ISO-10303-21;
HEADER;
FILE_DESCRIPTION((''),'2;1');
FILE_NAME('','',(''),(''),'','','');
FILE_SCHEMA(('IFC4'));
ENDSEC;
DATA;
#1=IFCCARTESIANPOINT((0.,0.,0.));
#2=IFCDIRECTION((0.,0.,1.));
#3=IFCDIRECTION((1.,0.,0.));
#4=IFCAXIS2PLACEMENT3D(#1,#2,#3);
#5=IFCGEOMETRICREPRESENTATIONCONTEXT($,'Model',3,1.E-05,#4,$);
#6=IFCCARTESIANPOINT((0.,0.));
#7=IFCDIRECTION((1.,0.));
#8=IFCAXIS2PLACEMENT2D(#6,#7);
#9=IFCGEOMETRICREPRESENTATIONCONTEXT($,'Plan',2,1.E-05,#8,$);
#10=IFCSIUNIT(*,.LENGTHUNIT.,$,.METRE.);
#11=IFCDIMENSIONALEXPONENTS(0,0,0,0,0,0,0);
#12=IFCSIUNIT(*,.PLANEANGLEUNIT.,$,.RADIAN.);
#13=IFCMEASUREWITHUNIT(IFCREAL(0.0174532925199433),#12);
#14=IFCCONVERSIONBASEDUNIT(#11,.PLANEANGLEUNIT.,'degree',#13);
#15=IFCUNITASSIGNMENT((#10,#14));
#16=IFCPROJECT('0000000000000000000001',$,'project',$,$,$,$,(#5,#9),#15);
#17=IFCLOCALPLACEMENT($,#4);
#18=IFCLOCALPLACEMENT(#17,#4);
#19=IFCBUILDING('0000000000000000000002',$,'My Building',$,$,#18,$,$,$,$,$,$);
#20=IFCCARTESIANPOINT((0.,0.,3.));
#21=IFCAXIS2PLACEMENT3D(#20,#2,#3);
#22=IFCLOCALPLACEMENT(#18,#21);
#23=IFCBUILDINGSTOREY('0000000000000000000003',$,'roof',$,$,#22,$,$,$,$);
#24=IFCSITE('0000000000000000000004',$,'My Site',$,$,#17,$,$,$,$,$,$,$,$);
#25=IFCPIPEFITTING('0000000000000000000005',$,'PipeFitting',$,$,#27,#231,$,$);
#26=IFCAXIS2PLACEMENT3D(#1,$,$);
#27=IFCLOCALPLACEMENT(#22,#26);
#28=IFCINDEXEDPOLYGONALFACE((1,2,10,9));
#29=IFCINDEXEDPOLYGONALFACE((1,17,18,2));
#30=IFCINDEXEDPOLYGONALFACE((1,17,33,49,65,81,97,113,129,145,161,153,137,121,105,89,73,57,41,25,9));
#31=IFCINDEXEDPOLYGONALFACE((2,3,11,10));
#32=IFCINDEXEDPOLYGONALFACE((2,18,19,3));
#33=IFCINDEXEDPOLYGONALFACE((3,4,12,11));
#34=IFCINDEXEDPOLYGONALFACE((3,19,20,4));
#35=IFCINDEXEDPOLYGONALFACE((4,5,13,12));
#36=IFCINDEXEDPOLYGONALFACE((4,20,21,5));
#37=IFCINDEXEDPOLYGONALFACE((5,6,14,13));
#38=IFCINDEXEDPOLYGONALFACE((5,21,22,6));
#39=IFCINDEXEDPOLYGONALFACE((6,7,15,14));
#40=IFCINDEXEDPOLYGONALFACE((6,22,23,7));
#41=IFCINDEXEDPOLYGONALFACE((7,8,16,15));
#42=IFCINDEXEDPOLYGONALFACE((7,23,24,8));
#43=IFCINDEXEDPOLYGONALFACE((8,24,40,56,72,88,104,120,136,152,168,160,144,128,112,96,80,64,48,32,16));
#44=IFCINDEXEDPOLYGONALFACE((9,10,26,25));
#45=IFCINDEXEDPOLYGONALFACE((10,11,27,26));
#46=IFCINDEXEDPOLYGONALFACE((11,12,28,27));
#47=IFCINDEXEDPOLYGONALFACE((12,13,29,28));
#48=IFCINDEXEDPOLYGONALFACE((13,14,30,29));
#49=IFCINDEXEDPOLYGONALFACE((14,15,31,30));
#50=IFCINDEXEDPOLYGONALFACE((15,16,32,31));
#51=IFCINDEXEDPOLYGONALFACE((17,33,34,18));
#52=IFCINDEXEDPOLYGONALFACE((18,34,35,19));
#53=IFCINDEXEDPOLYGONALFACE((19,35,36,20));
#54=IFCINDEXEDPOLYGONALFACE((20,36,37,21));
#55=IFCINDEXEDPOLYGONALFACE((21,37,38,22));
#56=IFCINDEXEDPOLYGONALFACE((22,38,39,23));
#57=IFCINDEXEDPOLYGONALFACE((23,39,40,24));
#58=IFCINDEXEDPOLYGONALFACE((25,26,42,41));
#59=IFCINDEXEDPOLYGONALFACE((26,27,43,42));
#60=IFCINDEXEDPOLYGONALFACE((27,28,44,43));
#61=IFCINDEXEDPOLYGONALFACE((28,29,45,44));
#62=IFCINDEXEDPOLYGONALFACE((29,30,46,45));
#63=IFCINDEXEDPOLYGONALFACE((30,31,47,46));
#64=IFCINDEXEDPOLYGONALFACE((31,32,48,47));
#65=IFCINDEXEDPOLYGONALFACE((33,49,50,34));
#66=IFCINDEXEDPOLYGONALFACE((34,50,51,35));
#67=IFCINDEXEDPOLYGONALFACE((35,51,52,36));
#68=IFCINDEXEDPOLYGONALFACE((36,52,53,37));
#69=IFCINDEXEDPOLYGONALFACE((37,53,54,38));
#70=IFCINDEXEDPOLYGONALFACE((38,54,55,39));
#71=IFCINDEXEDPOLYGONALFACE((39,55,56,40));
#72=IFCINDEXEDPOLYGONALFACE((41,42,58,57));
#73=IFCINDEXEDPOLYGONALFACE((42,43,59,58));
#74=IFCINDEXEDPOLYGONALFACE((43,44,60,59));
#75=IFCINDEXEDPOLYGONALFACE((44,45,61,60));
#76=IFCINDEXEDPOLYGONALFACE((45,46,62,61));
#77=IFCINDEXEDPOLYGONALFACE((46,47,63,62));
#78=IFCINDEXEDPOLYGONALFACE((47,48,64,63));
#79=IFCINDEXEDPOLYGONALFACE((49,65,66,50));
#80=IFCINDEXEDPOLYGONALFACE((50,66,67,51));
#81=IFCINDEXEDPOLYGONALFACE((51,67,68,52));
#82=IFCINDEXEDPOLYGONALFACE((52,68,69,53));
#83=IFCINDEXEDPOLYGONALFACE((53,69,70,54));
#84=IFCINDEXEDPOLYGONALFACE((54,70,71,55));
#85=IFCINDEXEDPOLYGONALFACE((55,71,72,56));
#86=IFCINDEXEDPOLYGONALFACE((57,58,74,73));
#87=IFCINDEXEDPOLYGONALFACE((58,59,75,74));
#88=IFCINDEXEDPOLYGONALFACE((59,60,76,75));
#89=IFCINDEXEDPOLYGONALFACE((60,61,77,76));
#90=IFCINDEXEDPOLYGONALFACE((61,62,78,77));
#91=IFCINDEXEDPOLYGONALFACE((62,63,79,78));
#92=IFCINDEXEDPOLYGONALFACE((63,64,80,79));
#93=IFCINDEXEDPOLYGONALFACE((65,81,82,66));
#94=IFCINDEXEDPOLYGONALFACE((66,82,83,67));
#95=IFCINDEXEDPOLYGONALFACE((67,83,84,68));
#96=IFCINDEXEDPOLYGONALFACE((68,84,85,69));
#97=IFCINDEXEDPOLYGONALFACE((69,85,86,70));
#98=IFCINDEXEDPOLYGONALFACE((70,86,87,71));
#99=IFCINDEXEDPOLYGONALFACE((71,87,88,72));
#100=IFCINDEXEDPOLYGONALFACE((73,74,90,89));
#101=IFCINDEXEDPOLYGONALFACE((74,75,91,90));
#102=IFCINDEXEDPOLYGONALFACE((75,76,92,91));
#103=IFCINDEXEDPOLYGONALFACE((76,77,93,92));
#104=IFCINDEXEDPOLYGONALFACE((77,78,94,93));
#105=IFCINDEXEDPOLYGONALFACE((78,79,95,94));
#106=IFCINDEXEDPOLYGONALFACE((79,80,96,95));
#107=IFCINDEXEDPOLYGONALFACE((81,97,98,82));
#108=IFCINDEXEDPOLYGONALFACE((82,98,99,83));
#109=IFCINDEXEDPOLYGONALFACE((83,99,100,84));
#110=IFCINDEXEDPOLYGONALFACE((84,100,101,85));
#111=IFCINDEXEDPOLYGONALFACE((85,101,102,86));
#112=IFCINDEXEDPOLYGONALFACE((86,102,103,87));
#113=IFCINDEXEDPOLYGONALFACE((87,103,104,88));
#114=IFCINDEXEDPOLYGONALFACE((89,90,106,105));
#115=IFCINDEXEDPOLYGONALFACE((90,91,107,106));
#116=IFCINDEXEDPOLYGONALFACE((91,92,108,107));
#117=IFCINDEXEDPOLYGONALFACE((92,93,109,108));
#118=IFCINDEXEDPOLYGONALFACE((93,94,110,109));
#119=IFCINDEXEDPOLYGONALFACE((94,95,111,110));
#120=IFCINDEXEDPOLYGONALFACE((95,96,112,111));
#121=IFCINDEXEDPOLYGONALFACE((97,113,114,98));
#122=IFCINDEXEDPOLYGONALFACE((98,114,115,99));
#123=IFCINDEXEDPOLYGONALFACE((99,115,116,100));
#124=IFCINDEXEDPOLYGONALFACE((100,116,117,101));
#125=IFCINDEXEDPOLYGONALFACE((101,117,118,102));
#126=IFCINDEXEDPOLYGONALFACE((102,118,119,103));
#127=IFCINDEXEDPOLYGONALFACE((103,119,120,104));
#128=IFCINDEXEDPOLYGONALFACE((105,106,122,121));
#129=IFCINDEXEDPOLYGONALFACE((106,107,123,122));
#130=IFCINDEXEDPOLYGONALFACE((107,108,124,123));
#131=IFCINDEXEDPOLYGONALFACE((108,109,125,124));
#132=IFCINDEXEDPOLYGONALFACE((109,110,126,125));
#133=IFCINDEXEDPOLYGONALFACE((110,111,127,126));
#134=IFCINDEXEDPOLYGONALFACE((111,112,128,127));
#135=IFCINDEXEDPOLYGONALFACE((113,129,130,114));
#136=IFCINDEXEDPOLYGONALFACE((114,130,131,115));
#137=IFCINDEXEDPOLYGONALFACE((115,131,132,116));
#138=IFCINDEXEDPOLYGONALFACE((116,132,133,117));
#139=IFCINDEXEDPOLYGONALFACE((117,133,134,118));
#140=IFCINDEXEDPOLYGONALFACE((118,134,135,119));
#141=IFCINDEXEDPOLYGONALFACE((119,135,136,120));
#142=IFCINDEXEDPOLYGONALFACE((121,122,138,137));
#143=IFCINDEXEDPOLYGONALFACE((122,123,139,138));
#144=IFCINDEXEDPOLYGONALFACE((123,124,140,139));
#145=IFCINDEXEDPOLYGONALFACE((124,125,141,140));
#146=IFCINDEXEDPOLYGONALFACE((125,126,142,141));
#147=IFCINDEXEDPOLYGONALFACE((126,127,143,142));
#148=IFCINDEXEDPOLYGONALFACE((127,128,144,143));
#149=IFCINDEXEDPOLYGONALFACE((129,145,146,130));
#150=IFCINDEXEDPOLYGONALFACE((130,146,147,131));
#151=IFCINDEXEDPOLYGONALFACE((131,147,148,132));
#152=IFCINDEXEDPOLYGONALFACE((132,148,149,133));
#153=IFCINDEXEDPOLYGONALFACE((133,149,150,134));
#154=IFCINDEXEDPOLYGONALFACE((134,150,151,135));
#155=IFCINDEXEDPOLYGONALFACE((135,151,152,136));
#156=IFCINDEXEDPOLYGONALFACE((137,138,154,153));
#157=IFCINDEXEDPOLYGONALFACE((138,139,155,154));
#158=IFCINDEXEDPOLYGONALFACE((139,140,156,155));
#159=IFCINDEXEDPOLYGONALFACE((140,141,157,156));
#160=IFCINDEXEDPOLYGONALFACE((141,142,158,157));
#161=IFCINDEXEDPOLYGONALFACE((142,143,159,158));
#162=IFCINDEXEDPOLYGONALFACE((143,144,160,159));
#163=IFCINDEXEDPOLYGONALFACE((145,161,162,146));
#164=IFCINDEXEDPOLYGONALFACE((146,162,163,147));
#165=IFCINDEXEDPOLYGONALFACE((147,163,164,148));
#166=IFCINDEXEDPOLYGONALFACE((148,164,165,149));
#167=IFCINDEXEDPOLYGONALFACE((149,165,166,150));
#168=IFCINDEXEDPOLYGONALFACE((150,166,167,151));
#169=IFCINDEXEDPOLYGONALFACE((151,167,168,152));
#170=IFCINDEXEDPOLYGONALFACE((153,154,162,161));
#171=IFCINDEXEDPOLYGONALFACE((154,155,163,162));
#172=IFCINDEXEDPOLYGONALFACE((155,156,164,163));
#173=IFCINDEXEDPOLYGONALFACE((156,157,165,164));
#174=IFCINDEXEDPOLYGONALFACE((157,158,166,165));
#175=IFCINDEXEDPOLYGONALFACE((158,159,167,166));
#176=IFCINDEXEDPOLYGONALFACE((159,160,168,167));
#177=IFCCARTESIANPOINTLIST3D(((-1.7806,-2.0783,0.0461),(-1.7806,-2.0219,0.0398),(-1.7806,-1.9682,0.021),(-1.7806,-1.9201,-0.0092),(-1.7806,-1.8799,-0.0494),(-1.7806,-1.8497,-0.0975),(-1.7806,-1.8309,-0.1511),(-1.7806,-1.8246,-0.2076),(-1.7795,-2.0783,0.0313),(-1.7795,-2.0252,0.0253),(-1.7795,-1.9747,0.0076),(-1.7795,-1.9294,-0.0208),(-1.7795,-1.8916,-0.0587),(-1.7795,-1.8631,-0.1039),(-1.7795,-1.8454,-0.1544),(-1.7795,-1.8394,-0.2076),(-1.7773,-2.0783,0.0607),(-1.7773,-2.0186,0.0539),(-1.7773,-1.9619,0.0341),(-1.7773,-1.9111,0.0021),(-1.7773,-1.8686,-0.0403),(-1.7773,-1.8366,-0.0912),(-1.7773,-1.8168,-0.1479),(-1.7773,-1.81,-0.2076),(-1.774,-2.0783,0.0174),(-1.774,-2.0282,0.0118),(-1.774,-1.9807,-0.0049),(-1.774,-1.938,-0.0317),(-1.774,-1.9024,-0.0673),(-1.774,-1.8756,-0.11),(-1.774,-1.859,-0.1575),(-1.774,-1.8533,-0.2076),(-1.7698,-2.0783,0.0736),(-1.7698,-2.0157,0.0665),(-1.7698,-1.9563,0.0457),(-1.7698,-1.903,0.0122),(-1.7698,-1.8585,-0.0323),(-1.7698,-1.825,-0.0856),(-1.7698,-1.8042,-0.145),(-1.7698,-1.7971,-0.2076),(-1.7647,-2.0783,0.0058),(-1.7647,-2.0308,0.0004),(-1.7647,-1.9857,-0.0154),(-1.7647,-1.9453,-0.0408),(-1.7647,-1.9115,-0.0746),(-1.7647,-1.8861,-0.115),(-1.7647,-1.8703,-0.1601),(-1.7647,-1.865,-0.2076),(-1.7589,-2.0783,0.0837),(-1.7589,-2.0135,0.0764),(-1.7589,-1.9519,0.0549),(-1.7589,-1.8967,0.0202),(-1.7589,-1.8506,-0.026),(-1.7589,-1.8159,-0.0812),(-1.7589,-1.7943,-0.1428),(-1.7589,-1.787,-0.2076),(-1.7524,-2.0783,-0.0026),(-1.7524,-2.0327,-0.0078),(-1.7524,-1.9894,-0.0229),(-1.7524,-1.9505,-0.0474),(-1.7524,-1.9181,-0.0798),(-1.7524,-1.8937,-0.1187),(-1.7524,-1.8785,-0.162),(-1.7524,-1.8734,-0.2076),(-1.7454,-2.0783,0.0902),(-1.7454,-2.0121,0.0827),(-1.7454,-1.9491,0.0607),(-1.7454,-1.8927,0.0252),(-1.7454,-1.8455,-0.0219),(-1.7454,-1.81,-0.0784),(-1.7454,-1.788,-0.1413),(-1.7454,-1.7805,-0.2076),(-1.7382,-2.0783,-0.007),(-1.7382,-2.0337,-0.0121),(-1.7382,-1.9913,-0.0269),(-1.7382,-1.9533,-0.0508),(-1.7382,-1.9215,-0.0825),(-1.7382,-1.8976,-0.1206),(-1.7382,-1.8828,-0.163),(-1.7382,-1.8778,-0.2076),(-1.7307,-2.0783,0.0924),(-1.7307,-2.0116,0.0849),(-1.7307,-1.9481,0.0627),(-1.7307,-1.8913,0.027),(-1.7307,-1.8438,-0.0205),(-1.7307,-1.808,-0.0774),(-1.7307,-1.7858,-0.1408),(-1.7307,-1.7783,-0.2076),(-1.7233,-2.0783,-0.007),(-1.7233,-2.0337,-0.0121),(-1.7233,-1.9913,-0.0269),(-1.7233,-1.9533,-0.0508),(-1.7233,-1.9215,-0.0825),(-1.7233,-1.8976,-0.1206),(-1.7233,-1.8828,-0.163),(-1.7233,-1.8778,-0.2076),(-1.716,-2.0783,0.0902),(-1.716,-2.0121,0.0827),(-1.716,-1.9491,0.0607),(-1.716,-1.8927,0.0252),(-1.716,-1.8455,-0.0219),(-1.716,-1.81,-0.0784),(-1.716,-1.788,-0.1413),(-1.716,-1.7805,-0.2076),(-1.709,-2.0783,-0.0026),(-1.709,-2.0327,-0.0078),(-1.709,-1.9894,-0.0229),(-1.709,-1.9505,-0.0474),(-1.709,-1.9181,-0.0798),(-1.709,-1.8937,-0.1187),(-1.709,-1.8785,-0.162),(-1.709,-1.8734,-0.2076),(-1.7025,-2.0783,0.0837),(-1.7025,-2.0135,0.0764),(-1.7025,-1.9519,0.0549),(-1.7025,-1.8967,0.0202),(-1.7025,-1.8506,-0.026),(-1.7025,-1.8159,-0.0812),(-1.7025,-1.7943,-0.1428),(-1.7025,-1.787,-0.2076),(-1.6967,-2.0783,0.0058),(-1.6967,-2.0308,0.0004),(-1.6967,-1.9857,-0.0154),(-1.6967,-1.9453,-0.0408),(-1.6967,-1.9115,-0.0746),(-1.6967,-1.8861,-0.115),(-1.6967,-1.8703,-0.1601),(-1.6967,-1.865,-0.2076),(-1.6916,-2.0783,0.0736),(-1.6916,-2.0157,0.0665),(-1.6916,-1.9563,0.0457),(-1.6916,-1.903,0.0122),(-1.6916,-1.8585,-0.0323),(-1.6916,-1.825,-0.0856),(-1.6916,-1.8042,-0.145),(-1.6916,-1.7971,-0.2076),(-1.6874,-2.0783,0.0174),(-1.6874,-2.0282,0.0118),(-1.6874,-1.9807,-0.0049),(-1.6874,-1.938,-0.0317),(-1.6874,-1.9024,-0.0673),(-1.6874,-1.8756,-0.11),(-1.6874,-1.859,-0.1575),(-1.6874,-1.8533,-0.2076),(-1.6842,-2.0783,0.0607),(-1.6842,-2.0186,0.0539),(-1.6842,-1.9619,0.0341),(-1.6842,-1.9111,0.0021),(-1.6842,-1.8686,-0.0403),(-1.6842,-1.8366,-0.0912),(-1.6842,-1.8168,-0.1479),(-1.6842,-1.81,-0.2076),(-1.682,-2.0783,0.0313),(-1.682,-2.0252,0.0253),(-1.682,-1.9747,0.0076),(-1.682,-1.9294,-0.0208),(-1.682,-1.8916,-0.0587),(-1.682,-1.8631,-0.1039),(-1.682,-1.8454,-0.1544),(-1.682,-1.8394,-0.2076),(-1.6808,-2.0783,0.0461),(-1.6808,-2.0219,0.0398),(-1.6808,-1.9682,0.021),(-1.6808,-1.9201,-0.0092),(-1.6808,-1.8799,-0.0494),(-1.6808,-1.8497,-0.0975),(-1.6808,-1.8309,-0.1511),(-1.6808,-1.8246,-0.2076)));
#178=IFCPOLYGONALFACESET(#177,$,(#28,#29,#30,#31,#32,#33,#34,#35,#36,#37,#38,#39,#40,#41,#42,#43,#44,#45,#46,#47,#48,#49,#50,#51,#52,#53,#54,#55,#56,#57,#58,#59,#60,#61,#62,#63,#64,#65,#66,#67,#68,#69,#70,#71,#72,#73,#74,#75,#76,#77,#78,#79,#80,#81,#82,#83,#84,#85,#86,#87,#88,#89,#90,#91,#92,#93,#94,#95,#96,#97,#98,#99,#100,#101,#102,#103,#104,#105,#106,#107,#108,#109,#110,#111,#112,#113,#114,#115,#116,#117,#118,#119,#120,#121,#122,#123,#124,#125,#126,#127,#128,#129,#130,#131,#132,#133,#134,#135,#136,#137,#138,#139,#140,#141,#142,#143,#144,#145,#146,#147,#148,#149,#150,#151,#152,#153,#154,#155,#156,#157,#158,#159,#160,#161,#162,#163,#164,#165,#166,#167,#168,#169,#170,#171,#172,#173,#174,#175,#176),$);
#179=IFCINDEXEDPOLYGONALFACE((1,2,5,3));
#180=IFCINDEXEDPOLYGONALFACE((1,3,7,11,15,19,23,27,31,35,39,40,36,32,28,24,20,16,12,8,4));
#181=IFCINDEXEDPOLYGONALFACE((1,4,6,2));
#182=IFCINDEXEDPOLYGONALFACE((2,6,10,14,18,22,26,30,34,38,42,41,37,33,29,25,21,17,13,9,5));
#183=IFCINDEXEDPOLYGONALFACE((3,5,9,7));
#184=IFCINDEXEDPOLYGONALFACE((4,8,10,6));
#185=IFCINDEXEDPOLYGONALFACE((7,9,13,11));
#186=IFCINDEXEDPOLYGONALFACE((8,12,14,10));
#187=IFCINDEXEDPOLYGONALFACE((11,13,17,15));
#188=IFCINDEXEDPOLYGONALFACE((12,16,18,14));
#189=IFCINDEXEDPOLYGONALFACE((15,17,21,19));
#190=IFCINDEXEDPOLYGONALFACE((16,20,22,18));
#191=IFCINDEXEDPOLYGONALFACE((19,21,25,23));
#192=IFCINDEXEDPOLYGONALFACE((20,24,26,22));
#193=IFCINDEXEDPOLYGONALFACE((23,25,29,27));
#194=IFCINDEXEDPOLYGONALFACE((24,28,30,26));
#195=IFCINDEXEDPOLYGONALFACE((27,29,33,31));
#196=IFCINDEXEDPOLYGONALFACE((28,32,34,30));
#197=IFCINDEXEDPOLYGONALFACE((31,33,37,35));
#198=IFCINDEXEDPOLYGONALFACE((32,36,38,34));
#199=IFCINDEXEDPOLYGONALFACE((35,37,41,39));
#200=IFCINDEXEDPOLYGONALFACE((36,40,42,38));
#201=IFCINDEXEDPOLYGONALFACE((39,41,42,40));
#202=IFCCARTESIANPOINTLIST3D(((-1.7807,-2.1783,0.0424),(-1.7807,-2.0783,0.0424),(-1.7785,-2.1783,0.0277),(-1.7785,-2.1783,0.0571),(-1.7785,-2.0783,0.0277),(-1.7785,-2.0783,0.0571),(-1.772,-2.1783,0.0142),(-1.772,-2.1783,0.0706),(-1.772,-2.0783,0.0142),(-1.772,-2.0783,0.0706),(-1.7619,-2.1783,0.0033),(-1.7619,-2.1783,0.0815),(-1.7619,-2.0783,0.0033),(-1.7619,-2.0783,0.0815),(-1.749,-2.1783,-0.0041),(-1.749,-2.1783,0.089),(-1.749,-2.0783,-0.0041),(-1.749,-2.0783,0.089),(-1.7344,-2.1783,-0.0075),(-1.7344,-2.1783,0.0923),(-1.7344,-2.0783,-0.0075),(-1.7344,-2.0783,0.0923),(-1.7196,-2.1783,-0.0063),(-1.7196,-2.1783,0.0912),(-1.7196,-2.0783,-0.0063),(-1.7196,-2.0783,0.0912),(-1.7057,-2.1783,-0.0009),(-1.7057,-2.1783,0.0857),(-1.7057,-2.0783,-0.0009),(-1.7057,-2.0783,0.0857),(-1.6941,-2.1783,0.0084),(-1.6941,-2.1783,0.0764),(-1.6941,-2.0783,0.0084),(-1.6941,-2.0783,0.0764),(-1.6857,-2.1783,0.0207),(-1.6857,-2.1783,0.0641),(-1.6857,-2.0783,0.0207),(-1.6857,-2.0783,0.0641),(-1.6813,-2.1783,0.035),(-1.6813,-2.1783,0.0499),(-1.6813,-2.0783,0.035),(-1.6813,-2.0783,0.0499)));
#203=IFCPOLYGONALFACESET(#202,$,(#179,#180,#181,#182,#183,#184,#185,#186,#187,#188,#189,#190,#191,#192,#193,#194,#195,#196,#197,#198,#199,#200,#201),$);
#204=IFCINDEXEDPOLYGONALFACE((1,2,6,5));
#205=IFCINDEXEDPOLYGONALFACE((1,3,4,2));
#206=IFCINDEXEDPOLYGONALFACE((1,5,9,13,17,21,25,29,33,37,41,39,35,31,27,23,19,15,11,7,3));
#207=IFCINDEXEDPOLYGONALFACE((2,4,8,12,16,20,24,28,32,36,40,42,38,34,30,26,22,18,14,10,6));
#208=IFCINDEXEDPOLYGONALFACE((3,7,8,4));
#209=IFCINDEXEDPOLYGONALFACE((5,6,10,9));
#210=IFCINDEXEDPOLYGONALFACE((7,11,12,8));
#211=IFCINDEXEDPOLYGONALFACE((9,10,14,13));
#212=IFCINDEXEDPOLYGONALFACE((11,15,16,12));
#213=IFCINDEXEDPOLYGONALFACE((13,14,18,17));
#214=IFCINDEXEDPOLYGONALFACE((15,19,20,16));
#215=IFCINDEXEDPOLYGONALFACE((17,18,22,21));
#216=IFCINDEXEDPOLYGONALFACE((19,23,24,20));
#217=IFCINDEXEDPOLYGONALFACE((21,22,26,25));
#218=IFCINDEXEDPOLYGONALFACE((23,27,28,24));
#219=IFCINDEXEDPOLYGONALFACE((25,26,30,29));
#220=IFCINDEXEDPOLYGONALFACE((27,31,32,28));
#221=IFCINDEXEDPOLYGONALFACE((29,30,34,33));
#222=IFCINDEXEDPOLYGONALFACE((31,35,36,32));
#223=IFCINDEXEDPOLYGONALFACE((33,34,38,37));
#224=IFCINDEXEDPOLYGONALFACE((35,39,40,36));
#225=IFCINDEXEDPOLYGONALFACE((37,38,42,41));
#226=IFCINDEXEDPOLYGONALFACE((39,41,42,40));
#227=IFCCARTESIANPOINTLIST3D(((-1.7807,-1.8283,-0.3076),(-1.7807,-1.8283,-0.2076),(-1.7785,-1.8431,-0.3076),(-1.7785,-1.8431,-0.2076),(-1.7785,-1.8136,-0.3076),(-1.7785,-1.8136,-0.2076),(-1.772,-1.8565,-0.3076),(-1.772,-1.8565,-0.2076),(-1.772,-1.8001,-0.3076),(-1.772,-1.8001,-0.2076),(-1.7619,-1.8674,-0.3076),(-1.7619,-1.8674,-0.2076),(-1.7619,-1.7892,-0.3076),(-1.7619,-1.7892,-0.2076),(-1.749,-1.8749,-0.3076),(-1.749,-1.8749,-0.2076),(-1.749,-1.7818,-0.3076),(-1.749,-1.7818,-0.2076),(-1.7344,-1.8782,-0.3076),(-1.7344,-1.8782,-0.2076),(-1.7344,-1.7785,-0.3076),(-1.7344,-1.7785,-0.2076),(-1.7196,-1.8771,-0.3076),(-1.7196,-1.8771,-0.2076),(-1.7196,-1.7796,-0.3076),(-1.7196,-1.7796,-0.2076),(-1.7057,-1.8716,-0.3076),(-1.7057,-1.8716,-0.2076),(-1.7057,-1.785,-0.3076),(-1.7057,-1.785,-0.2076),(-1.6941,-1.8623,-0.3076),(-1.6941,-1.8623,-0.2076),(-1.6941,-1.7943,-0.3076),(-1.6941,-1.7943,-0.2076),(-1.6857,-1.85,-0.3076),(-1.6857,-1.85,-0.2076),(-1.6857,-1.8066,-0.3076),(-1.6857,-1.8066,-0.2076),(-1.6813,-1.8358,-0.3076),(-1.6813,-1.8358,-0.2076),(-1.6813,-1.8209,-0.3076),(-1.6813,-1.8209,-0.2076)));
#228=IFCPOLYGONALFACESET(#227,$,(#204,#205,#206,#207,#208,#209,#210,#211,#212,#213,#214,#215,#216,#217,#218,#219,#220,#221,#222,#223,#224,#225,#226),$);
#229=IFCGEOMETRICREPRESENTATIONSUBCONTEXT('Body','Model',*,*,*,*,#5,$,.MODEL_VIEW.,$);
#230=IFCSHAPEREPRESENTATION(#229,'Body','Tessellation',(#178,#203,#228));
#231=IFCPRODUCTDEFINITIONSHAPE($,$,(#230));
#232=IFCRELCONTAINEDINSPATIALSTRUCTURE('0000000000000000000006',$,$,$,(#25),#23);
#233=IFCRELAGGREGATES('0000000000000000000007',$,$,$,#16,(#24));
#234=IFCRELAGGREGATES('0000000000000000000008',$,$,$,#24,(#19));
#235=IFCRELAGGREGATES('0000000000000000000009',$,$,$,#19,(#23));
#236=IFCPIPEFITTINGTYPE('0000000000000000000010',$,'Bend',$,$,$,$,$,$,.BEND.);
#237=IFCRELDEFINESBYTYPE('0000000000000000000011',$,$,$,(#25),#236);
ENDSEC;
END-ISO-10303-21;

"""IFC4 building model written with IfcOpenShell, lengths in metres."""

from ifc_helpers import new_model, entity, si_unit, converted_unit, frame, origin_with_axes, origin_2d_with_axis, place, context, subcontext, project, spatial, circle, extrude, source, transform, mapped, type_object, type_shapes, element, save


model = new_model("IFC4")

# Units and contexts
model_context = context("Model", 3, precision=1e-05, world=origin_with_axes())
plan_context = context("Plan", 2, precision=1e-05, world=origin_2d_with_axis())
body_context = subcontext(model_context, "Body", "Model", "MODEL_VIEW")
ifc_project = project(units=[si_unit("LENGTHUNIT", "METRE"), converted_unit("PLANEANGLEUNIT", "degree", entity("IfcReal", 0.0174532925199433), si_unit("PLANEANGLEUNIT", "RADIAN"), dimensions=[0, 0, 0, 0, 0, 0, 0])], contexts=[model_context, plan_context])

# Site, building, storey
site_placement = place(None, origin_with_axes())
site = spatial("IfcSite", under=ifc_project, at=site_placement, Name="My Site")
building_placement = place(site_placement, origin_with_axes())
building = spatial("IfcBuilding", under=site, at=building_placement, Name="My Building")
storey_placement = place(building_placement, frame((0.0, 0.0, 3.0), z_axis=(0.0, 0.0, 1.0), x_axis=(1.0, 0.0, 0.0)))
storey = spatial("IfcBuildingStorey", under=building, at=storey_placement, Name="roof")

# Pipe fitting
pipe_fitting_type_1 = type_object("IfcPipeFittingType", Name="Bend", PredefinedType="BEND")
shared_shape_1 = source(origin_with_axes(), body_context, "Body", "SolidModel", [
    entity("IfcSweptDiskSolid", entity("IfcIndexedPolyCurve", entity("IfcCartesianPointList3D", [[0.0, 0.0, 0.1], [0.0, -0.0732, 0.2768], [0.0, -0.25, 0.35]]), [entity("IfcArcIndex", [1, 2, 3])]), 0.05),
    extrude(circle(Radius=0.05), origin_with_axes(), (0.0, 0.0, 1.0), 0.1),
    extrude(circle(Radius=0.05), frame((0.0, -0.25, 0.35), z_axis=(0.0, -1.0, 0.000008), x_axis=(1.0, 0.0, 0.0)), (0.0, 0.0, 1.0), 0.1),
])
type_shapes(pipe_fitting_type_1, [shared_shape_1])
pipe_fitting_placement = place(storey_placement, frame((-1.7307, -2.1783, 0.0424), z_axis=(0.0, 1.0, -0.000008), x_axis=(-1.0, 0.0, 0.0)))
element("IfcPipeFitting", 1, at=pipe_fitting_placement, inside=storey, type_object=pipe_fitting_type_1, Name="PipeFitting", context=body_context, shape_type="MappedRepresentation", body=[
    mapped(shared_shape_1, transform((0.0, 0.0, 0.0), x_axis=(1.0, 0.0, 0.0), y_axis=(0.0, 1.0, 0.0), z_axis=(0.0, 0.0, 1.0), scale=1.0)),
])

save(model, "model.ifc")
